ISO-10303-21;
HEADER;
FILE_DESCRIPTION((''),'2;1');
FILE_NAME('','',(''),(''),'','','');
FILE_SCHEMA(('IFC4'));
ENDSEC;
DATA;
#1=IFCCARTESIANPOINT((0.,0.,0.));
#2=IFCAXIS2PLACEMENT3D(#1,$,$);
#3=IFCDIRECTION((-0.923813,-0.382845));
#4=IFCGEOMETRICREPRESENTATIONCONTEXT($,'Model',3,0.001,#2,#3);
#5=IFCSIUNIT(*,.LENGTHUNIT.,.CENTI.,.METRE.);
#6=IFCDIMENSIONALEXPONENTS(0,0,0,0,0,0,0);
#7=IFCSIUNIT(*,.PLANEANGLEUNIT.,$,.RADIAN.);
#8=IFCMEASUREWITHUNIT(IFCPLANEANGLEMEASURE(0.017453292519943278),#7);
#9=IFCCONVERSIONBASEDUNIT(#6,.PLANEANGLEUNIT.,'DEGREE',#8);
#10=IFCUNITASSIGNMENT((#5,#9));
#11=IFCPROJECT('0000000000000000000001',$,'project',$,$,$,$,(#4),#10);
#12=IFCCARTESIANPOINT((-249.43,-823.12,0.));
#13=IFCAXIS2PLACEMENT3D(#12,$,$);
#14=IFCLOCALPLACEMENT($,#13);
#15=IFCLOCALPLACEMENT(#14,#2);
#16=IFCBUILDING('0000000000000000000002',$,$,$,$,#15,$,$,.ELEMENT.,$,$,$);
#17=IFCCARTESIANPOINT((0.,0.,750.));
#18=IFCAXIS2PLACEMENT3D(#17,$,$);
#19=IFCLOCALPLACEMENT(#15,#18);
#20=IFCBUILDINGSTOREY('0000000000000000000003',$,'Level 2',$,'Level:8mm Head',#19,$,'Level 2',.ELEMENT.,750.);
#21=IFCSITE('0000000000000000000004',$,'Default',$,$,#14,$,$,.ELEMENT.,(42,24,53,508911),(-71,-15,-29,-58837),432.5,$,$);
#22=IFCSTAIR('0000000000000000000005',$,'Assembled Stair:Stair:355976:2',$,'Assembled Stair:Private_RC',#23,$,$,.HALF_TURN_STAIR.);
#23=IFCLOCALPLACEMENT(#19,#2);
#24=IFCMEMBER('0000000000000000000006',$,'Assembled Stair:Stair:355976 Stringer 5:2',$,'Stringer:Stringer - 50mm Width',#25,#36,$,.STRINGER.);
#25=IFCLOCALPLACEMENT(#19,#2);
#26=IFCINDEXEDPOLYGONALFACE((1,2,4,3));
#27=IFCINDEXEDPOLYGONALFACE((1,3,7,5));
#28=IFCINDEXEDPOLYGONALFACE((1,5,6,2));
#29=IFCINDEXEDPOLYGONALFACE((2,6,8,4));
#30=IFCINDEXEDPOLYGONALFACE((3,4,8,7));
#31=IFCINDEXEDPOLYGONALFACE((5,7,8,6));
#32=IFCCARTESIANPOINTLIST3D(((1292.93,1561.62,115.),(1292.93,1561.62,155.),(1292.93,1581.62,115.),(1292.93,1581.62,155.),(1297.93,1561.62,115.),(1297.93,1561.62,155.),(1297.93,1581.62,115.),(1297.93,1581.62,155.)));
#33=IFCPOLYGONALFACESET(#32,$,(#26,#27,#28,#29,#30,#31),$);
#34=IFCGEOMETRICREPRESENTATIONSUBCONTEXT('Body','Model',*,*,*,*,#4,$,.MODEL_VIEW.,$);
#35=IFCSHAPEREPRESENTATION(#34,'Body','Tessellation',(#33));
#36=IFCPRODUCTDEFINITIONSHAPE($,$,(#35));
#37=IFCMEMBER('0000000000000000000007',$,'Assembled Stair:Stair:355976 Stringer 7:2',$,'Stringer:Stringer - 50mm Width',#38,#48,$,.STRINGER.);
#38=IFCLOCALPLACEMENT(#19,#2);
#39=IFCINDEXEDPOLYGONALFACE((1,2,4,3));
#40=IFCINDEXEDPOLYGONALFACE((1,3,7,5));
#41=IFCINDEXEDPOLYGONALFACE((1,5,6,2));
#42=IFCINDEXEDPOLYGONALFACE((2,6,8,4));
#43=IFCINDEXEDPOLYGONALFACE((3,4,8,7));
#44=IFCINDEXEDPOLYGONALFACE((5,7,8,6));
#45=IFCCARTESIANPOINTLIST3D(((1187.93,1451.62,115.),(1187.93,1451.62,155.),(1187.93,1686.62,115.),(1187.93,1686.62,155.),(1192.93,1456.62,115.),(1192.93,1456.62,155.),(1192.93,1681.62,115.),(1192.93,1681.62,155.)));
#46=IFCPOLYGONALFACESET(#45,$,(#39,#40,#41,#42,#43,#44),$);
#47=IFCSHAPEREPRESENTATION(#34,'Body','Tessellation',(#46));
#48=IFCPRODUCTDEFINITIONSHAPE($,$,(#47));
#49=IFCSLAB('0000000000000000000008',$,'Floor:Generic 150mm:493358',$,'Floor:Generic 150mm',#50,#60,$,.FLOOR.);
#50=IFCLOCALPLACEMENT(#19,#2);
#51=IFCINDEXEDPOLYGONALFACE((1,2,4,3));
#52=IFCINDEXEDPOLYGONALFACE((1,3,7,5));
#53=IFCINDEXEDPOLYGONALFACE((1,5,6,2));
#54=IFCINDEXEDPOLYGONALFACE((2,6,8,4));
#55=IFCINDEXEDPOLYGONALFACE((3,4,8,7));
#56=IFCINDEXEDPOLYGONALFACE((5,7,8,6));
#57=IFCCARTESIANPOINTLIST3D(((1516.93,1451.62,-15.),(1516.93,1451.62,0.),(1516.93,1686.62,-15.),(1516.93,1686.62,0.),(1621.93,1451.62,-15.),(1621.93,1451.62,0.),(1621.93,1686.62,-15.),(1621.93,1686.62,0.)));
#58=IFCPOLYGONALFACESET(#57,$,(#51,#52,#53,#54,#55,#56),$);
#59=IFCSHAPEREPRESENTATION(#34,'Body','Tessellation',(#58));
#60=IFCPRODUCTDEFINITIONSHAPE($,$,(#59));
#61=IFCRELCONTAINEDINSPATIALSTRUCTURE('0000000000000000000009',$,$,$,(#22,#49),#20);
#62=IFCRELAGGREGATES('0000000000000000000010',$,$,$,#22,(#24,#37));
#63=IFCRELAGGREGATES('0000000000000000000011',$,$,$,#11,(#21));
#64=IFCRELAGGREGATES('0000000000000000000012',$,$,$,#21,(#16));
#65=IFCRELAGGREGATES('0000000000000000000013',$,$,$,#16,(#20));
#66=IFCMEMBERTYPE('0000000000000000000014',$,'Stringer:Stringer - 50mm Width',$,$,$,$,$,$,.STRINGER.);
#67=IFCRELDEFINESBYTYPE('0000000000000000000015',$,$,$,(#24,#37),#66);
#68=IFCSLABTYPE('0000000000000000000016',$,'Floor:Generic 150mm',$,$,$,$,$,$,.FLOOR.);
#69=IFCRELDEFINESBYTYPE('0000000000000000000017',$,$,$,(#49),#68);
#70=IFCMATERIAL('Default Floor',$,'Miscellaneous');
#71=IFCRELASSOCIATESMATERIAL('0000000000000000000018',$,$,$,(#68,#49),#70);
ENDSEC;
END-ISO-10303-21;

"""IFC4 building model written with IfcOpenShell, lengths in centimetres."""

from ifc_helpers import new_model, entity, si_unit, converted_unit, direction, frame, origin, place, context, subcontext, project, spatial, indexed_curve, outline, extrude, material, type_object, element, aggregate, save


model = new_model("IFC4")

# Units and contexts
model_context = context("Model", 3, precision=0.001, world=origin(), true_north=direction((-0.923813, -0.382845)))
body_context = subcontext(model_context, "Body", "Model", "MODEL_VIEW")
ifc_project = project(units=[si_unit("LENGTHUNIT", "METRE", prefix="CENTI"), converted_unit("PLANEANGLEUNIT", "DEGREE", entity("IfcPlaneAngleMeasure", 0.017453292519943278), si_unit("PLANEANGLEUNIT", "RADIAN"), dimensions=[0, 0, 0, 0, 0, 0, 0])], contexts=[model_context])

# Site, building, storey
site_placement = place(None, frame((-249.43, -823.12, 0.0)))
site = spatial("IfcSite", under=ifc_project, at=site_placement, Name="Default", CompositionType="ELEMENT", RefLatitude=(42, 24, 53, 508911), RefLongitude=(-71, -15, -29, -58837), RefElevation=432.5)
building_placement = place(site_placement, origin())
building = spatial("IfcBuilding", under=site, at=building_placement, CompositionType="ELEMENT")
storey_placement = place(building_placement, frame((0.0, 0.0, 750.0)))
storey = spatial("IfcBuildingStorey", under=building, at=storey_placement, Name="Level 2", ObjectType="Level:8mm Head", LongName="Level 2", CompositionType="ELEMENT", Elevation=750.0)

# Stair, members
stair_placement = place(storey_placement, origin())
stair = element("IfcStair", 1, at=stair_placement, inside=storey, Name="Assembled Stair:Stair:355976:2", ObjectType="Assembled Stair:Private_RC", PredefinedType="HALF_TURN_STAIR")
member_type = type_object("IfcMemberType", Name="Stringer:Stringer - 50mm Width", PredefinedType="STRINGER")
member_1_placement = place(stair_placement, origin())
member_1 = element("IfcMember", 2, at=member_1_placement, type_object=member_type, Name="Assembled Stair:Stair:355976 Stringer 5:2", ObjectType="Stringer:Stringer - 50mm Width", PredefinedType="STRINGER", context=body_context, shape_type="SweptSolid", body=[
    extrude(outline(indexed_curve([(-10.0, -2.5), (10.0, -2.5), (10.0, 2.5), (-10.0, 2.5), (-10.0, -2.5)], self_intersect=False)), frame((1295.43, 1571.62, 115.0), z_axis=(0.0, 0.0, 1.0), x_axis=(0.0, 1.0, 0.0)), (0.0, 0.0, 1.0), 40.0),
])
member_2_placement = place(stair_placement, origin())
member_2 = element("IfcMember", 3, at=member_2_placement, type_object=member_type, Name="Assembled Stair:Stair:355976 Stringer 7:2", ObjectType="Stringer:Stringer - 50mm Width", PredefinedType="STRINGER", context=body_context, shape_type="SweptSolid", body=[
    extrude(outline(indexed_curve([(-117.5, -2.5), (117.5, -2.5), (112.5, 2.5), (-112.5, 2.5), (-117.5, -2.5)], self_intersect=False)), frame((1190.43, 1569.12, 115.0), z_axis=(0.0, 0.0, 1.0), x_axis=(0.0, -1.0, 0.0)), (0.0, 0.0, 1.0), 40.0),
])

# Slab
ifc_material_1 = material(Name="Default Floor", Category="Miscellaneous")
slab_type_1 = type_object("IfcSlabType", Name="Floor:Generic 150mm", PredefinedType="FLOOR", material=ifc_material_1)
slab_1_placement = place(storey_placement, origin())
element("IfcSlab", 4, at=slab_1_placement, inside=storey, type_object=slab_type_1, material=ifc_material_1, Name="Floor:Generic 150mm:493358", ObjectType="Floor:Generic 150mm", PredefinedType="FLOOR", context=body_context, shape_type="SweptSolid", body=[
    extrude(outline(indexed_curve([(-117.5, -52.5), (117.5, -52.5), (117.5, 52.5), (-117.5, 52.5), (-117.5, -52.5)], self_intersect=False)), frame((1569.43, 1569.12, 0.0), z_axis=(0.0, 0.0, -1.0), x_axis=(0.0, 1.0, 0.0)), (0.0, 0.0, 1.0), 15.0),
])

aggregate(stair, [member_1, member_2])

save(model, "model.ifc")
